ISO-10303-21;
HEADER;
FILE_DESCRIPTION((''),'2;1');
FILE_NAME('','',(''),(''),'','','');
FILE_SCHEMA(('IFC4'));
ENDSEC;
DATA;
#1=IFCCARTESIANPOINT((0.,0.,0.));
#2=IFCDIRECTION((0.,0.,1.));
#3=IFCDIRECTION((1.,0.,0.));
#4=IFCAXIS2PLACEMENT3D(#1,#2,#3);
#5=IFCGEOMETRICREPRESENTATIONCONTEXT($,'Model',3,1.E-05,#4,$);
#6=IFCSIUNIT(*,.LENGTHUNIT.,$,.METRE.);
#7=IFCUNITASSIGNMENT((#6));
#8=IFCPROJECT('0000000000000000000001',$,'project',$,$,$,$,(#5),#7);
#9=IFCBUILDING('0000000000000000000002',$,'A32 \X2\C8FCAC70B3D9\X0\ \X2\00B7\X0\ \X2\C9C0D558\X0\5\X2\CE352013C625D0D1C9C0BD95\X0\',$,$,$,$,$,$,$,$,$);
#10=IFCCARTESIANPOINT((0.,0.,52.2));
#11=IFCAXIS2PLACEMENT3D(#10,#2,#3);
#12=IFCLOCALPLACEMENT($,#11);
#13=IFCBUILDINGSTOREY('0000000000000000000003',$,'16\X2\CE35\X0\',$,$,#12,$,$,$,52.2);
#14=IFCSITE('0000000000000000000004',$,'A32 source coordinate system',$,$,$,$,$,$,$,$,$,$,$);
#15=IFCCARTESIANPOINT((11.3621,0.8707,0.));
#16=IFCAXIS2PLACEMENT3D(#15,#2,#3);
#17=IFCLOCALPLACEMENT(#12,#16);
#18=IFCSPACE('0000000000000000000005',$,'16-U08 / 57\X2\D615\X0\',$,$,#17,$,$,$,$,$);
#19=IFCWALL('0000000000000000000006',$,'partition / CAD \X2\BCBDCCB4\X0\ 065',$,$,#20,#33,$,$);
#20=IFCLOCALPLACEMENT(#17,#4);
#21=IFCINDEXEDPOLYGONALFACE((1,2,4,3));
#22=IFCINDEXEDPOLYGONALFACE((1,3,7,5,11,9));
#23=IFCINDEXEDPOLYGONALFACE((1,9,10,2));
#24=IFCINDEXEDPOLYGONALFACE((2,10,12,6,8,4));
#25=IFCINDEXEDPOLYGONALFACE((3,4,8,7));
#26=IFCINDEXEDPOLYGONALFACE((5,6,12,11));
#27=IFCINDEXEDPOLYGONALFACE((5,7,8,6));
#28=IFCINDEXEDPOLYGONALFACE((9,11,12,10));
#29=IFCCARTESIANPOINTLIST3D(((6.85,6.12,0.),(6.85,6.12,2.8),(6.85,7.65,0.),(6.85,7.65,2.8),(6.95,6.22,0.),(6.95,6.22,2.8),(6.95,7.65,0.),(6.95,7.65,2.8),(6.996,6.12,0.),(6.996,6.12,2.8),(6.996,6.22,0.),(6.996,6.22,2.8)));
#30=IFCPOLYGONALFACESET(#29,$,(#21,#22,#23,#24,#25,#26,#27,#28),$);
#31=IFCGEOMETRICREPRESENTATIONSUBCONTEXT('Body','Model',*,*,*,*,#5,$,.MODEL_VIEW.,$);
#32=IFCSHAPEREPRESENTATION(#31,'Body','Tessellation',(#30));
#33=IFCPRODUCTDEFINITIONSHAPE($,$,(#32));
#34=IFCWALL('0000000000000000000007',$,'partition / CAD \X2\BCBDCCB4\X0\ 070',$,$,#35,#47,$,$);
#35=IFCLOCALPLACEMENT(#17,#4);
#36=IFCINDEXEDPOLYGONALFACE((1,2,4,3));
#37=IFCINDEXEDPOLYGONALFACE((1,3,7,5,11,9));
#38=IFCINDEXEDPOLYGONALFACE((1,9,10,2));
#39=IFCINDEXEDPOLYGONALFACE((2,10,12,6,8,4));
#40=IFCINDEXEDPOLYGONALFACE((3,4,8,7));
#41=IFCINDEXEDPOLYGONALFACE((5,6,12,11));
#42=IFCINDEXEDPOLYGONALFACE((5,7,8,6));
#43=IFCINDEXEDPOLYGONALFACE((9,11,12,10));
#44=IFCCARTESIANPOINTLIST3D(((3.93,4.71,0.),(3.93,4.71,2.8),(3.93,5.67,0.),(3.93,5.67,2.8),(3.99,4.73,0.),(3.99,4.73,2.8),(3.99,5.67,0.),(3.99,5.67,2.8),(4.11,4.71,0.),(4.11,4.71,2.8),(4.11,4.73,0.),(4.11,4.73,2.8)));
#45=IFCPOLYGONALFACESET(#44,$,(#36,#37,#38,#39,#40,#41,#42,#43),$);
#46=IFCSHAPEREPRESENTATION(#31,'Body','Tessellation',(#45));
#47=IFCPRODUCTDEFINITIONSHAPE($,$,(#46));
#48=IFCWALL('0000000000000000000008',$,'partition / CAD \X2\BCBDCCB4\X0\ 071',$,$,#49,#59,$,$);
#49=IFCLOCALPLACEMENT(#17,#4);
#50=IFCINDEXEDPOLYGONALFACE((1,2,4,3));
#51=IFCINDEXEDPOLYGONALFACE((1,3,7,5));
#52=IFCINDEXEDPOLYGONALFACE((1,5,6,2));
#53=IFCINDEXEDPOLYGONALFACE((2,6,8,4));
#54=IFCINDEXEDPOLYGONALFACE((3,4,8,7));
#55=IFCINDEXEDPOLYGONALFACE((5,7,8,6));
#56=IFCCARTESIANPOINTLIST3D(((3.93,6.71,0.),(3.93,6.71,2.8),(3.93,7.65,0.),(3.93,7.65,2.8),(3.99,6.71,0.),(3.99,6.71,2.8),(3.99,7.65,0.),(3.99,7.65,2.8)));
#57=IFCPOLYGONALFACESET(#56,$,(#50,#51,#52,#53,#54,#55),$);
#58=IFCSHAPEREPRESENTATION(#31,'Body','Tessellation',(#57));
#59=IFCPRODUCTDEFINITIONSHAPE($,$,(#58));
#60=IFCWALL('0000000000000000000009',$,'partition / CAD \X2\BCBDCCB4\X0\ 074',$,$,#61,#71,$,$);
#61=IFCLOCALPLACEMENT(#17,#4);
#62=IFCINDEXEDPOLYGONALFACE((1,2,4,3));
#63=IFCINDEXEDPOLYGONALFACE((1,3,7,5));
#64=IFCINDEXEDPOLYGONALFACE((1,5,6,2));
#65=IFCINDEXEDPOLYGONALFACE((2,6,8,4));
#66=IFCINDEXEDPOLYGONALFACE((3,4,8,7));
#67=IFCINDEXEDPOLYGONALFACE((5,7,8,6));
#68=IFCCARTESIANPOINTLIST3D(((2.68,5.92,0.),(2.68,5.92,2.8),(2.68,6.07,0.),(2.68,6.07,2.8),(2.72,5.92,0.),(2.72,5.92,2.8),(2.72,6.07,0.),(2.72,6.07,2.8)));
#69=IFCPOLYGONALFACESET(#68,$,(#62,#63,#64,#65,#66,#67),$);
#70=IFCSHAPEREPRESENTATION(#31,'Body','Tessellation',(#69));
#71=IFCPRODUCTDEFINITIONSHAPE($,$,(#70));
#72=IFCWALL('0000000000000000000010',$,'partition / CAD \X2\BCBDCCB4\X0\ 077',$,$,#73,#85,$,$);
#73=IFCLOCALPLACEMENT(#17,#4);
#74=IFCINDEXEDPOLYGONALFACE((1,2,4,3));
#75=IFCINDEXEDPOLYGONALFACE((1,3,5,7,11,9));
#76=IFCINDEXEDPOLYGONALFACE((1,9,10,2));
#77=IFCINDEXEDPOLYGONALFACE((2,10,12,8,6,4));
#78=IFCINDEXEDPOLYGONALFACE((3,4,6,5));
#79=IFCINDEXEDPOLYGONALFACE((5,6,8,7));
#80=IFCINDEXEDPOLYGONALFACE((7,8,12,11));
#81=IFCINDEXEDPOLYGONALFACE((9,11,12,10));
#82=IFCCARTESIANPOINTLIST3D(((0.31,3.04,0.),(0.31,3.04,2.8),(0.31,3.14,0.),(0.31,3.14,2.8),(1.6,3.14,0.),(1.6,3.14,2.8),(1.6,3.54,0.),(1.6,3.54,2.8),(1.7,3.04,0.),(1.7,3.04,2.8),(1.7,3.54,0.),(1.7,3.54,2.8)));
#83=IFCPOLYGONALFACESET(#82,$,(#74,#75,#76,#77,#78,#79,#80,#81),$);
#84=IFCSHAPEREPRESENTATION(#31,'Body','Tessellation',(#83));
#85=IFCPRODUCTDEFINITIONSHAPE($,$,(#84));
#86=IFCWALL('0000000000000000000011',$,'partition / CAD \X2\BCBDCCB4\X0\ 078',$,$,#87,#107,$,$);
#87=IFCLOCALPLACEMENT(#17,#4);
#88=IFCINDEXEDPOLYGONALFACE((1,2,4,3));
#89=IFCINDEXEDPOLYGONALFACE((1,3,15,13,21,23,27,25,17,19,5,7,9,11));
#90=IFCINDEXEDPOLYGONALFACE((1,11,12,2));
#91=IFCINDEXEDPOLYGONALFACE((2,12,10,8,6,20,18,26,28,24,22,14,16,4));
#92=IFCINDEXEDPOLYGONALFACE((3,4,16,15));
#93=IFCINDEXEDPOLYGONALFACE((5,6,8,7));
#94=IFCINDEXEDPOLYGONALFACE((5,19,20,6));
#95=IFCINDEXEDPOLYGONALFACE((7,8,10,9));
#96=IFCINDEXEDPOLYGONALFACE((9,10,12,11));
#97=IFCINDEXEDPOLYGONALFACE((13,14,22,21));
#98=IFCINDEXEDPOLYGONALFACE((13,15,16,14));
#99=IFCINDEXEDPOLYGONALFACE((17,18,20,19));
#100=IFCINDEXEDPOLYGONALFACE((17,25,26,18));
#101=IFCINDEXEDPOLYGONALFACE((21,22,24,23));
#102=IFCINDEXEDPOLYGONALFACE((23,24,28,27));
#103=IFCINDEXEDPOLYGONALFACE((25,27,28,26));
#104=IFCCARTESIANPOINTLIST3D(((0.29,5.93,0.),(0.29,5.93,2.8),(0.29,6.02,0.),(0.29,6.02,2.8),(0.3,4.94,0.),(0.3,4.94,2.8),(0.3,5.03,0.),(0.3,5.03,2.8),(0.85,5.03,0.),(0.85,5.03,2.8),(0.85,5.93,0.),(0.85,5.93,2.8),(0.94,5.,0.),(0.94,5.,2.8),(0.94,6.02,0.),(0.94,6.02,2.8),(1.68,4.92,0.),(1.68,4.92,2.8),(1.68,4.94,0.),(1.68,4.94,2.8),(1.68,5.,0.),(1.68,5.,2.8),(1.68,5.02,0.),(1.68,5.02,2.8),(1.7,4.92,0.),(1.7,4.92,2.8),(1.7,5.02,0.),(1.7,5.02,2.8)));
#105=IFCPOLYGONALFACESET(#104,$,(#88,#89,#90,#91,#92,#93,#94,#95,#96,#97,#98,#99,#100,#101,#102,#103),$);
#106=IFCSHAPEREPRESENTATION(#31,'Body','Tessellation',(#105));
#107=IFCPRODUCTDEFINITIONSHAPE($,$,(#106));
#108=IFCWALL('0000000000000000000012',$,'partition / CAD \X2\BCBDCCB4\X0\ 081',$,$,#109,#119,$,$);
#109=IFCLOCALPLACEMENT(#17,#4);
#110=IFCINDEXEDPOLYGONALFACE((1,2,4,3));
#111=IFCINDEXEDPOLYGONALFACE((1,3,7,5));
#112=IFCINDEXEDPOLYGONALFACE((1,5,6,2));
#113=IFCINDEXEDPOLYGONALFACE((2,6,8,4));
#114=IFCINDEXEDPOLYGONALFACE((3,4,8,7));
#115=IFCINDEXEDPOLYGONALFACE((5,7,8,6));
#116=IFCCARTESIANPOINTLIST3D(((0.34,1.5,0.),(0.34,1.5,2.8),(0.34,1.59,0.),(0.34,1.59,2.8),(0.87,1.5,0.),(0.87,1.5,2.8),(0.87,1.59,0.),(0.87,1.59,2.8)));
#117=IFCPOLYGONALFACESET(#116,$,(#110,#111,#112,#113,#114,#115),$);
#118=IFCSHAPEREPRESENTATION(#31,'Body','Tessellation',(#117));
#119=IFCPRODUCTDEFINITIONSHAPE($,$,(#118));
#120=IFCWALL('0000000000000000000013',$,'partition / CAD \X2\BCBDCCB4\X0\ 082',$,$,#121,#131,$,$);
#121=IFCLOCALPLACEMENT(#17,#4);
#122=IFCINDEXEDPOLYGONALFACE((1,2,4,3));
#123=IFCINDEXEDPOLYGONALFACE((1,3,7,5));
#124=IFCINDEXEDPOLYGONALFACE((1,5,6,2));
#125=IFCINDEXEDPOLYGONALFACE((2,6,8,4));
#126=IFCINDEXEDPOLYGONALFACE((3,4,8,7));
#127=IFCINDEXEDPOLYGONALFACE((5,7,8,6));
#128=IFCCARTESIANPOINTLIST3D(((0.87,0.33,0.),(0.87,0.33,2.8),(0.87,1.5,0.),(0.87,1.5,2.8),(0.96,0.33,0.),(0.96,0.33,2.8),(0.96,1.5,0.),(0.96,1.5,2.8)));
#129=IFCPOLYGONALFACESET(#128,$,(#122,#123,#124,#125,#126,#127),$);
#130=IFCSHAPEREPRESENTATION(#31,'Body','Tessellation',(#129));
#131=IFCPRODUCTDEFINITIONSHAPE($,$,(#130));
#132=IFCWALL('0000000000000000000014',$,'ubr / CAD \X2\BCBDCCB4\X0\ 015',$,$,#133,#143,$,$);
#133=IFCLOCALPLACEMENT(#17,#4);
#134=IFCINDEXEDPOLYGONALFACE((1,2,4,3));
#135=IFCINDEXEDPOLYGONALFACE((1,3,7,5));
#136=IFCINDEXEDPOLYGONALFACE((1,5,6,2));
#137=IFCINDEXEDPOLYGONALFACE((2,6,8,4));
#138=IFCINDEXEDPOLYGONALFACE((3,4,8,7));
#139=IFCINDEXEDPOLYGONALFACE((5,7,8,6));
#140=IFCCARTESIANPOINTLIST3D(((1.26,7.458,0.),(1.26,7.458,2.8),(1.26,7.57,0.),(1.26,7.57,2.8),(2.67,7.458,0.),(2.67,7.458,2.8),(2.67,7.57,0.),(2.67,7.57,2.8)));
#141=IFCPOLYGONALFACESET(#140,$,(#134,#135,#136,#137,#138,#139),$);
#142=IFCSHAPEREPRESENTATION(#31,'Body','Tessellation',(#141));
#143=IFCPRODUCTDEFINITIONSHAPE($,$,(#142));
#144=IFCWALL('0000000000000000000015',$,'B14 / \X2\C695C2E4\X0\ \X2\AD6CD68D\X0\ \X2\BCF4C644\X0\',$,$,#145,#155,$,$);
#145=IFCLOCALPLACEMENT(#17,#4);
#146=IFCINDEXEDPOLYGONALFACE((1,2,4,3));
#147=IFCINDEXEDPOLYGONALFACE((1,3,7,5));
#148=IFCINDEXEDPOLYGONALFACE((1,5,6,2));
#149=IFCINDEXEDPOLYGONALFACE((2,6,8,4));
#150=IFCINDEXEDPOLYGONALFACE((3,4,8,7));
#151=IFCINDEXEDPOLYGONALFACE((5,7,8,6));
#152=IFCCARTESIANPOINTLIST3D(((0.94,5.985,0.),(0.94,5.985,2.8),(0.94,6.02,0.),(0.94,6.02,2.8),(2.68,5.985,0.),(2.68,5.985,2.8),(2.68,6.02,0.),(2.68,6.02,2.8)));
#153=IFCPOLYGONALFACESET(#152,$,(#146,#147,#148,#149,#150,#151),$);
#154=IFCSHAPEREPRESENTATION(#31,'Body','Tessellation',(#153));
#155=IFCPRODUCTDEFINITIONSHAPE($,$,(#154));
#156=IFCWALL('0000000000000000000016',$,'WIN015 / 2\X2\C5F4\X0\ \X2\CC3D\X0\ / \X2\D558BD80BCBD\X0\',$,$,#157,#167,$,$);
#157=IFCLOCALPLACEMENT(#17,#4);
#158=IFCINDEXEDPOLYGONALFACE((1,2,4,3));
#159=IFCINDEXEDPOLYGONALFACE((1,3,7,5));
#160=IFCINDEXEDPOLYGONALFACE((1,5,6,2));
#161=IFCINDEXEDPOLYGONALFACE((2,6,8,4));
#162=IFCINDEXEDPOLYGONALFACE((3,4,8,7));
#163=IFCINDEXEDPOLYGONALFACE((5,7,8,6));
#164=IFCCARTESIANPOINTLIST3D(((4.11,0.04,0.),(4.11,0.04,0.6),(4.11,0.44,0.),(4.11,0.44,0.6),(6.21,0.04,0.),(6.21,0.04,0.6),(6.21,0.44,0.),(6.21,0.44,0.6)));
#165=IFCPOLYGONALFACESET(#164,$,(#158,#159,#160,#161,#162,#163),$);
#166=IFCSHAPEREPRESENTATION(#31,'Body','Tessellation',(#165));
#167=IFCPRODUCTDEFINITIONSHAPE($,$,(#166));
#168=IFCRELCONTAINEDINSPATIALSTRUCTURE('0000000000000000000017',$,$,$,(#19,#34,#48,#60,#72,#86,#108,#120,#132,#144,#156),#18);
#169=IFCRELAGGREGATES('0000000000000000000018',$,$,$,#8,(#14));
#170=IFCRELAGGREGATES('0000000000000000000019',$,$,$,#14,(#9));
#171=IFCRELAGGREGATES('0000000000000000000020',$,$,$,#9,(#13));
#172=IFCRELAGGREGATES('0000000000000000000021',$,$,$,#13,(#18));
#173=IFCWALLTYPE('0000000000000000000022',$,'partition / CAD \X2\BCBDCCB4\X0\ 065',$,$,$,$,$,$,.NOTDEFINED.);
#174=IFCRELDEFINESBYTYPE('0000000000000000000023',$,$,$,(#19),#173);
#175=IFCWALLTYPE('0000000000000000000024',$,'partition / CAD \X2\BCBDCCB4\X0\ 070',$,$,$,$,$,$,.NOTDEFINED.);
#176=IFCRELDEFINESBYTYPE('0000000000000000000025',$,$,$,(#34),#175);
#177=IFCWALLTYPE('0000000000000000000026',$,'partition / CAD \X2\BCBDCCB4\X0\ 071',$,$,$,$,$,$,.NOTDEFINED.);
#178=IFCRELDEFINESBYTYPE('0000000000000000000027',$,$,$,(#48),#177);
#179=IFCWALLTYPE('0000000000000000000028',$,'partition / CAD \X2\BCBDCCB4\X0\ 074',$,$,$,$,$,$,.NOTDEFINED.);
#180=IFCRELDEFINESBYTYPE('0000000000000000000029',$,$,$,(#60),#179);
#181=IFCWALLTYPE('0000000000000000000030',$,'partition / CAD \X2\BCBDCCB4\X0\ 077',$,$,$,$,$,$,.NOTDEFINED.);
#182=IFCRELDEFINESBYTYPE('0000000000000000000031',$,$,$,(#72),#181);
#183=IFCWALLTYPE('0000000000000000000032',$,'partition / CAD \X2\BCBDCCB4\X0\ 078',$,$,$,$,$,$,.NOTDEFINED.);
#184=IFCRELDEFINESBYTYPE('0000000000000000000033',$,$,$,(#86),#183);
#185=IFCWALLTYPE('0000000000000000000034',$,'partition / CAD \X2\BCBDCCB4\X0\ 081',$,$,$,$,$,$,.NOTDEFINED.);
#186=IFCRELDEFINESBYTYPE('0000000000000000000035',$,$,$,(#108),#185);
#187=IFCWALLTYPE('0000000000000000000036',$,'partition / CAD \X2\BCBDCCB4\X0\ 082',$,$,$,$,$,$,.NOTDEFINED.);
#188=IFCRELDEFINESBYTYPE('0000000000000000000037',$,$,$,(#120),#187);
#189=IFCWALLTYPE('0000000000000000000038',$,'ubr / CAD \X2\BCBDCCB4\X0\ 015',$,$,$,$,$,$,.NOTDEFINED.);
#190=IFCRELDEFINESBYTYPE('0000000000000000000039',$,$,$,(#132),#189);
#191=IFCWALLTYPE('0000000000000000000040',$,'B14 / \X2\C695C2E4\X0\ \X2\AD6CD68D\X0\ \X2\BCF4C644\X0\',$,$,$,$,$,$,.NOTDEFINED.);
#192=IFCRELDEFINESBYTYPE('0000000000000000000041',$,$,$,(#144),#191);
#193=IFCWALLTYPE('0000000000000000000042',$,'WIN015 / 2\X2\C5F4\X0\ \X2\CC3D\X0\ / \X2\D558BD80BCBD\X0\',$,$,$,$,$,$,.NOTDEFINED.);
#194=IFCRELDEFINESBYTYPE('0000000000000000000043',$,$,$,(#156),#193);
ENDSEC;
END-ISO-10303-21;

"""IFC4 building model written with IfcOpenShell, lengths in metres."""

from ifc_helpers import new_model, si_unit, frame, origin, origin_with_axes, place, context, subcontext, project, spatial, polyline, outline, extrude, source, transform, mapped, type_object, type_shapes, element, save


model = new_model("IFC4")

# Units and contexts
model_context = context("Model", 3, precision=1e-05, world=origin_with_axes())
body_context = subcontext(model_context, "Body", "Model", "MODEL_VIEW")
ifc_project = project(units=[si_unit("LENGTHUNIT", "METRE")], contexts=[model_context])

# Site, building, storey, space
storey_placement = place(None, frame((0.0, 0.0, 52.2), z_axis=(0.0, 0.0, 1.0), x_axis=(1.0, 0.0, 0.0)))
space_placement = place(storey_placement, frame((11.3621, 0.8707, 0.0), z_axis=(0.0, 0.0, 1.0), x_axis=(1.0, 0.0, 0.0)))
site = spatial("IfcSite", under=ifc_project, Name="A32 source coordinate system")
building = spatial("IfcBuilding", under=site, Name="A32 주거동 · 지하5층–옥탑지붕")
storey = spatial("IfcBuildingStorey", under=building, at=storey_placement, Name="16층", Elevation=52.2)
space = spatial("IfcSpace", under=storey, at=space_placement, Name="16-U08 / 57형")

# Walls
wall_type_1 = type_object("IfcWallType", Name="partition / CAD 벽체 065", PredefinedType="NOTDEFINED")
shared_shape_1 = source(origin(), body_context, "Body", "SweptSolid", [
    extrude(outline(polyline([(6.95, 7.65), (6.95, 6.22), (6.996, 6.22), (6.996, 6.12), (6.85, 6.12), (6.85, 7.65), (6.95, 7.65)])), origin(), (0.0, 0.0, 1.0), 2.8),
])
type_shapes(wall_type_1, [shared_shape_1])
wall_1_placement = place(space_placement, origin_with_axes())
element("IfcWall", 1, at=wall_1_placement, inside=space, type_object=wall_type_1, Name="partition / CAD 벽체 065", context=body_context, shape_type="MappedRepresentation", body=[
    mapped(shared_shape_1, transform((0.0, 0.0, 0.0), scale=1.0)),
])
wall_type_2 = type_object("IfcWallType", Name="partition / CAD 벽체 070", PredefinedType="NOTDEFINED")
shared_shape_2 = source(origin(), body_context, "Body", "SweptSolid", [
    extrude(outline(polyline([(4.11, 4.73), (4.11, 4.71), (3.93, 4.71), (3.93, 5.67), (3.99, 5.67), (3.99, 4.73), (4.11, 4.73)])), origin(), (0.0, 0.0, 1.0), 2.8),
])
type_shapes(wall_type_2, [shared_shape_2])
wall_2_placement = place(space_placement, origin_with_axes())
element("IfcWall", 2, at=wall_2_placement, inside=space, type_object=wall_type_2, Name="partition / CAD 벽체 070", context=body_context, shape_type="MappedRepresentation", body=[
    mapped(shared_shape_2, transform((0.0, 0.0, 0.0), scale=1.0)),
])
wall_type_3 = type_object("IfcWallType", Name="partition / CAD 벽체 071", PredefinedType="NOTDEFINED")
shared_shape_3 = source(origin(), body_context, "Body", "SweptSolid", [
    extrude(outline(polyline([(3.93, 6.71), (3.93, 7.65), (3.99, 7.65), (3.99, 6.71), (3.93, 6.71)])), origin(), (0.0, 0.0, 1.0), 2.8),
])
type_shapes(wall_type_3, [shared_shape_3])
wall_3_placement = place(space_placement, origin_with_axes())
element("IfcWall", 3, at=wall_3_placement, inside=space, type_object=wall_type_3, Name="partition / CAD 벽체 071", context=body_context, shape_type="MappedRepresentation", body=[
    mapped(shared_shape_3, transform((0.0, 0.0, 0.0), scale=1.0)),
])
wall_type_4 = type_object("IfcWallType", Name="partition / CAD 벽체 074", PredefinedType="NOTDEFINED")
shared_shape_4 = source(origin(), body_context, "Body", "SweptSolid", [
    extrude(outline(polyline([(2.72, 6.07), (2.72, 5.92), (2.68, 5.92), (2.68, 6.07), (2.72, 6.07)])), origin(), (0.0, 0.0, 1.0), 2.8),
])
type_shapes(wall_type_4, [shared_shape_4])
wall_4_placement = place(space_placement, origin_with_axes())
element("IfcWall", 4, at=wall_4_placement, inside=space, type_object=wall_type_4, Name="partition / CAD 벽체 074", context=body_context, shape_type="MappedRepresentation", body=[
    mapped(shared_shape_4, transform((0.0, 0.0, 0.0), scale=1.0)),
])
wall_type_5 = type_object("IfcWallType", Name="partition / CAD 벽체 077", PredefinedType="NOTDEFINED")
shared_shape_5 = source(origin(), body_context, "Body", "SweptSolid", [
    extrude(outline(polyline([(1.7, 3.54), (1.7, 3.04), (0.31, 3.04), (0.31, 3.14), (1.6, 3.14), (1.6, 3.54), (1.7, 3.54)])), origin(), (0.0, 0.0, 1.0), 2.8),
])
type_shapes(wall_type_5, [shared_shape_5])
wall_5_placement = place(space_placement, origin_with_axes())
element("IfcWall", 5, at=wall_5_placement, inside=space, type_object=wall_type_5, Name="partition / CAD 벽체 077", context=body_context, shape_type="MappedRepresentation", body=[
    mapped(shared_shape_5, transform((0.0, 0.0, 0.0), scale=1.0)),
])
wall_type_6 = type_object("IfcWallType", Name="partition / CAD 벽체 078", PredefinedType="NOTDEFINED")
shared_shape_6 = source(origin(), body_context, "Body", "SweptSolid", [
    extrude(outline(polyline([(1.7, 4.92), (1.68, 4.92), (1.68, 4.94), (0.3, 4.94), (0.3, 5.03), (0.85, 5.03), (0.85, 5.93), (0.29, 5.93), (0.29, 6.02), (0.94, 6.02), (0.94, 5.0), (1.68, 5.0), (1.68, 5.02), (1.7, 5.02), (1.7, 4.92)])), origin(), (0.0, 0.0, 1.0), 2.8),
])
type_shapes(wall_type_6, [shared_shape_6])
wall_6_placement = place(space_placement, origin_with_axes())
element("IfcWall", 6, at=wall_6_placement, inside=space, type_object=wall_type_6, Name="partition / CAD 벽체 078", context=body_context, shape_type="MappedRepresentation", body=[
    mapped(shared_shape_6, transform((0.0, 0.0, 0.0), scale=1.0)),
])
wall_type_7 = type_object("IfcWallType", Name="partition / CAD 벽체 081", PredefinedType="NOTDEFINED")
shared_shape_7 = source(origin(), body_context, "Body", "SweptSolid", [
    extrude(outline(polyline([(0.34, 1.59), (0.87, 1.59), (0.87, 1.5), (0.34, 1.5), (0.34, 1.59)])), origin(), (0.0, 0.0, 1.0), 2.8),
])
type_shapes(wall_type_7, [shared_shape_7])
wall_7_placement = place(space_placement, origin_with_axes())
element("IfcWall", 7, at=wall_7_placement, inside=space, type_object=wall_type_7, Name="partition / CAD 벽체 081", context=body_context, shape_type="MappedRepresentation", body=[
    mapped(shared_shape_7, transform((0.0, 0.0, 0.0), scale=1.0)),
])
wall_type_8 = type_object("IfcWallType", Name="partition / CAD 벽체 082", PredefinedType="NOTDEFINED")
shared_shape_8 = source(origin(), body_context, "Body", "SweptSolid", [
    extrude(outline(polyline([(0.96, 0.33), (0.87, 0.33), (0.87, 1.5), (0.96, 1.5), (0.96, 0.33)])), origin(), (0.0, 0.0, 1.0), 2.8),
])
type_shapes(wall_type_8, [shared_shape_8])
wall_8_placement = place(space_placement, origin_with_axes())
element("IfcWall", 8, at=wall_8_placement, inside=space, type_object=wall_type_8, Name="partition / CAD 벽체 082", context=body_context, shape_type="MappedRepresentation", body=[
    mapped(shared_shape_8, transform((0.0, 0.0, 0.0), scale=1.0)),
])
wall_type_9 = type_object("IfcWallType", Name="ubr / CAD 벽체 015", PredefinedType="NOTDEFINED")
shared_shape_9 = source(origin(), body_context, "Body", "SweptSolid", [
    extrude(outline(polyline([(2.67, 7.57), (2.67, 7.458), (1.26, 7.458), (1.26, 7.57), (2.67, 7.57)])), origin(), (0.0, 0.0, 1.0), 2.8),
])
type_shapes(wall_type_9, [shared_shape_9])
wall_9_placement = place(space_placement, origin_with_axes())
element("IfcWall", 9, at=wall_9_placement, inside=space, type_object=wall_type_9, Name="ubr / CAD 벽체 015", context=body_context, shape_type="MappedRepresentation", body=[
    mapped(shared_shape_9, transform((0.0, 0.0, 0.0), scale=1.0)),
])
wall_type_10 = type_object("IfcWallType", Name="B14 / 욕실 구획 보완", PredefinedType="NOTDEFINED")
shared_shape_10 = source(origin(), body_context, "Body", "SweptSolid", [
    extrude(outline(polyline([(2.68, 5.985), (0.94, 5.985), (0.94, 6.02), (2.68, 6.02), (2.68, 5.985)])), origin(), (0.0, 0.0, 1.0), 2.8),
])
type_shapes(wall_type_10, [shared_shape_10])
wall_10_placement = place(space_placement, origin_with_axes())
element("IfcWall", 10, at=wall_10_placement, inside=space, type_object=wall_type_10, Name="B14 / 욕실 구획 보완", context=body_context, shape_type="MappedRepresentation", body=[
    mapped(shared_shape_10, transform((0.0, 0.0, 0.0), scale=1.0)),
])
wall_type_11 = type_object("IfcWallType", Name="WIN015 / 2열 창 / 하부벽", PredefinedType="NOTDEFINED")
shared_shape_11 = source(origin(), body_context, "Body", "SweptSolid", [
    extrude(outline(polyline([(4.11, 0.04), (4.11, 0.44), (6.21, 0.44), (6.21, 0.04), (4.11, 0.04)])), origin(), (0.0, 0.0, 1.0), 0.6),
])
type_shapes(wall_type_11, [shared_shape_11])
wall_11_placement = place(space_placement, origin_with_axes())
element("IfcWall", 11, at=wall_11_placement, inside=space, type_object=wall_type_11, Name="WIN015 / 2열 창 / 하부벽", context=body_context, shape_type="MappedRepresentation", body=[
    mapped(shared_shape_11, transform((0.0, 0.0, 0.0), scale=1.0)),
])

save(model, "model.ifc")
